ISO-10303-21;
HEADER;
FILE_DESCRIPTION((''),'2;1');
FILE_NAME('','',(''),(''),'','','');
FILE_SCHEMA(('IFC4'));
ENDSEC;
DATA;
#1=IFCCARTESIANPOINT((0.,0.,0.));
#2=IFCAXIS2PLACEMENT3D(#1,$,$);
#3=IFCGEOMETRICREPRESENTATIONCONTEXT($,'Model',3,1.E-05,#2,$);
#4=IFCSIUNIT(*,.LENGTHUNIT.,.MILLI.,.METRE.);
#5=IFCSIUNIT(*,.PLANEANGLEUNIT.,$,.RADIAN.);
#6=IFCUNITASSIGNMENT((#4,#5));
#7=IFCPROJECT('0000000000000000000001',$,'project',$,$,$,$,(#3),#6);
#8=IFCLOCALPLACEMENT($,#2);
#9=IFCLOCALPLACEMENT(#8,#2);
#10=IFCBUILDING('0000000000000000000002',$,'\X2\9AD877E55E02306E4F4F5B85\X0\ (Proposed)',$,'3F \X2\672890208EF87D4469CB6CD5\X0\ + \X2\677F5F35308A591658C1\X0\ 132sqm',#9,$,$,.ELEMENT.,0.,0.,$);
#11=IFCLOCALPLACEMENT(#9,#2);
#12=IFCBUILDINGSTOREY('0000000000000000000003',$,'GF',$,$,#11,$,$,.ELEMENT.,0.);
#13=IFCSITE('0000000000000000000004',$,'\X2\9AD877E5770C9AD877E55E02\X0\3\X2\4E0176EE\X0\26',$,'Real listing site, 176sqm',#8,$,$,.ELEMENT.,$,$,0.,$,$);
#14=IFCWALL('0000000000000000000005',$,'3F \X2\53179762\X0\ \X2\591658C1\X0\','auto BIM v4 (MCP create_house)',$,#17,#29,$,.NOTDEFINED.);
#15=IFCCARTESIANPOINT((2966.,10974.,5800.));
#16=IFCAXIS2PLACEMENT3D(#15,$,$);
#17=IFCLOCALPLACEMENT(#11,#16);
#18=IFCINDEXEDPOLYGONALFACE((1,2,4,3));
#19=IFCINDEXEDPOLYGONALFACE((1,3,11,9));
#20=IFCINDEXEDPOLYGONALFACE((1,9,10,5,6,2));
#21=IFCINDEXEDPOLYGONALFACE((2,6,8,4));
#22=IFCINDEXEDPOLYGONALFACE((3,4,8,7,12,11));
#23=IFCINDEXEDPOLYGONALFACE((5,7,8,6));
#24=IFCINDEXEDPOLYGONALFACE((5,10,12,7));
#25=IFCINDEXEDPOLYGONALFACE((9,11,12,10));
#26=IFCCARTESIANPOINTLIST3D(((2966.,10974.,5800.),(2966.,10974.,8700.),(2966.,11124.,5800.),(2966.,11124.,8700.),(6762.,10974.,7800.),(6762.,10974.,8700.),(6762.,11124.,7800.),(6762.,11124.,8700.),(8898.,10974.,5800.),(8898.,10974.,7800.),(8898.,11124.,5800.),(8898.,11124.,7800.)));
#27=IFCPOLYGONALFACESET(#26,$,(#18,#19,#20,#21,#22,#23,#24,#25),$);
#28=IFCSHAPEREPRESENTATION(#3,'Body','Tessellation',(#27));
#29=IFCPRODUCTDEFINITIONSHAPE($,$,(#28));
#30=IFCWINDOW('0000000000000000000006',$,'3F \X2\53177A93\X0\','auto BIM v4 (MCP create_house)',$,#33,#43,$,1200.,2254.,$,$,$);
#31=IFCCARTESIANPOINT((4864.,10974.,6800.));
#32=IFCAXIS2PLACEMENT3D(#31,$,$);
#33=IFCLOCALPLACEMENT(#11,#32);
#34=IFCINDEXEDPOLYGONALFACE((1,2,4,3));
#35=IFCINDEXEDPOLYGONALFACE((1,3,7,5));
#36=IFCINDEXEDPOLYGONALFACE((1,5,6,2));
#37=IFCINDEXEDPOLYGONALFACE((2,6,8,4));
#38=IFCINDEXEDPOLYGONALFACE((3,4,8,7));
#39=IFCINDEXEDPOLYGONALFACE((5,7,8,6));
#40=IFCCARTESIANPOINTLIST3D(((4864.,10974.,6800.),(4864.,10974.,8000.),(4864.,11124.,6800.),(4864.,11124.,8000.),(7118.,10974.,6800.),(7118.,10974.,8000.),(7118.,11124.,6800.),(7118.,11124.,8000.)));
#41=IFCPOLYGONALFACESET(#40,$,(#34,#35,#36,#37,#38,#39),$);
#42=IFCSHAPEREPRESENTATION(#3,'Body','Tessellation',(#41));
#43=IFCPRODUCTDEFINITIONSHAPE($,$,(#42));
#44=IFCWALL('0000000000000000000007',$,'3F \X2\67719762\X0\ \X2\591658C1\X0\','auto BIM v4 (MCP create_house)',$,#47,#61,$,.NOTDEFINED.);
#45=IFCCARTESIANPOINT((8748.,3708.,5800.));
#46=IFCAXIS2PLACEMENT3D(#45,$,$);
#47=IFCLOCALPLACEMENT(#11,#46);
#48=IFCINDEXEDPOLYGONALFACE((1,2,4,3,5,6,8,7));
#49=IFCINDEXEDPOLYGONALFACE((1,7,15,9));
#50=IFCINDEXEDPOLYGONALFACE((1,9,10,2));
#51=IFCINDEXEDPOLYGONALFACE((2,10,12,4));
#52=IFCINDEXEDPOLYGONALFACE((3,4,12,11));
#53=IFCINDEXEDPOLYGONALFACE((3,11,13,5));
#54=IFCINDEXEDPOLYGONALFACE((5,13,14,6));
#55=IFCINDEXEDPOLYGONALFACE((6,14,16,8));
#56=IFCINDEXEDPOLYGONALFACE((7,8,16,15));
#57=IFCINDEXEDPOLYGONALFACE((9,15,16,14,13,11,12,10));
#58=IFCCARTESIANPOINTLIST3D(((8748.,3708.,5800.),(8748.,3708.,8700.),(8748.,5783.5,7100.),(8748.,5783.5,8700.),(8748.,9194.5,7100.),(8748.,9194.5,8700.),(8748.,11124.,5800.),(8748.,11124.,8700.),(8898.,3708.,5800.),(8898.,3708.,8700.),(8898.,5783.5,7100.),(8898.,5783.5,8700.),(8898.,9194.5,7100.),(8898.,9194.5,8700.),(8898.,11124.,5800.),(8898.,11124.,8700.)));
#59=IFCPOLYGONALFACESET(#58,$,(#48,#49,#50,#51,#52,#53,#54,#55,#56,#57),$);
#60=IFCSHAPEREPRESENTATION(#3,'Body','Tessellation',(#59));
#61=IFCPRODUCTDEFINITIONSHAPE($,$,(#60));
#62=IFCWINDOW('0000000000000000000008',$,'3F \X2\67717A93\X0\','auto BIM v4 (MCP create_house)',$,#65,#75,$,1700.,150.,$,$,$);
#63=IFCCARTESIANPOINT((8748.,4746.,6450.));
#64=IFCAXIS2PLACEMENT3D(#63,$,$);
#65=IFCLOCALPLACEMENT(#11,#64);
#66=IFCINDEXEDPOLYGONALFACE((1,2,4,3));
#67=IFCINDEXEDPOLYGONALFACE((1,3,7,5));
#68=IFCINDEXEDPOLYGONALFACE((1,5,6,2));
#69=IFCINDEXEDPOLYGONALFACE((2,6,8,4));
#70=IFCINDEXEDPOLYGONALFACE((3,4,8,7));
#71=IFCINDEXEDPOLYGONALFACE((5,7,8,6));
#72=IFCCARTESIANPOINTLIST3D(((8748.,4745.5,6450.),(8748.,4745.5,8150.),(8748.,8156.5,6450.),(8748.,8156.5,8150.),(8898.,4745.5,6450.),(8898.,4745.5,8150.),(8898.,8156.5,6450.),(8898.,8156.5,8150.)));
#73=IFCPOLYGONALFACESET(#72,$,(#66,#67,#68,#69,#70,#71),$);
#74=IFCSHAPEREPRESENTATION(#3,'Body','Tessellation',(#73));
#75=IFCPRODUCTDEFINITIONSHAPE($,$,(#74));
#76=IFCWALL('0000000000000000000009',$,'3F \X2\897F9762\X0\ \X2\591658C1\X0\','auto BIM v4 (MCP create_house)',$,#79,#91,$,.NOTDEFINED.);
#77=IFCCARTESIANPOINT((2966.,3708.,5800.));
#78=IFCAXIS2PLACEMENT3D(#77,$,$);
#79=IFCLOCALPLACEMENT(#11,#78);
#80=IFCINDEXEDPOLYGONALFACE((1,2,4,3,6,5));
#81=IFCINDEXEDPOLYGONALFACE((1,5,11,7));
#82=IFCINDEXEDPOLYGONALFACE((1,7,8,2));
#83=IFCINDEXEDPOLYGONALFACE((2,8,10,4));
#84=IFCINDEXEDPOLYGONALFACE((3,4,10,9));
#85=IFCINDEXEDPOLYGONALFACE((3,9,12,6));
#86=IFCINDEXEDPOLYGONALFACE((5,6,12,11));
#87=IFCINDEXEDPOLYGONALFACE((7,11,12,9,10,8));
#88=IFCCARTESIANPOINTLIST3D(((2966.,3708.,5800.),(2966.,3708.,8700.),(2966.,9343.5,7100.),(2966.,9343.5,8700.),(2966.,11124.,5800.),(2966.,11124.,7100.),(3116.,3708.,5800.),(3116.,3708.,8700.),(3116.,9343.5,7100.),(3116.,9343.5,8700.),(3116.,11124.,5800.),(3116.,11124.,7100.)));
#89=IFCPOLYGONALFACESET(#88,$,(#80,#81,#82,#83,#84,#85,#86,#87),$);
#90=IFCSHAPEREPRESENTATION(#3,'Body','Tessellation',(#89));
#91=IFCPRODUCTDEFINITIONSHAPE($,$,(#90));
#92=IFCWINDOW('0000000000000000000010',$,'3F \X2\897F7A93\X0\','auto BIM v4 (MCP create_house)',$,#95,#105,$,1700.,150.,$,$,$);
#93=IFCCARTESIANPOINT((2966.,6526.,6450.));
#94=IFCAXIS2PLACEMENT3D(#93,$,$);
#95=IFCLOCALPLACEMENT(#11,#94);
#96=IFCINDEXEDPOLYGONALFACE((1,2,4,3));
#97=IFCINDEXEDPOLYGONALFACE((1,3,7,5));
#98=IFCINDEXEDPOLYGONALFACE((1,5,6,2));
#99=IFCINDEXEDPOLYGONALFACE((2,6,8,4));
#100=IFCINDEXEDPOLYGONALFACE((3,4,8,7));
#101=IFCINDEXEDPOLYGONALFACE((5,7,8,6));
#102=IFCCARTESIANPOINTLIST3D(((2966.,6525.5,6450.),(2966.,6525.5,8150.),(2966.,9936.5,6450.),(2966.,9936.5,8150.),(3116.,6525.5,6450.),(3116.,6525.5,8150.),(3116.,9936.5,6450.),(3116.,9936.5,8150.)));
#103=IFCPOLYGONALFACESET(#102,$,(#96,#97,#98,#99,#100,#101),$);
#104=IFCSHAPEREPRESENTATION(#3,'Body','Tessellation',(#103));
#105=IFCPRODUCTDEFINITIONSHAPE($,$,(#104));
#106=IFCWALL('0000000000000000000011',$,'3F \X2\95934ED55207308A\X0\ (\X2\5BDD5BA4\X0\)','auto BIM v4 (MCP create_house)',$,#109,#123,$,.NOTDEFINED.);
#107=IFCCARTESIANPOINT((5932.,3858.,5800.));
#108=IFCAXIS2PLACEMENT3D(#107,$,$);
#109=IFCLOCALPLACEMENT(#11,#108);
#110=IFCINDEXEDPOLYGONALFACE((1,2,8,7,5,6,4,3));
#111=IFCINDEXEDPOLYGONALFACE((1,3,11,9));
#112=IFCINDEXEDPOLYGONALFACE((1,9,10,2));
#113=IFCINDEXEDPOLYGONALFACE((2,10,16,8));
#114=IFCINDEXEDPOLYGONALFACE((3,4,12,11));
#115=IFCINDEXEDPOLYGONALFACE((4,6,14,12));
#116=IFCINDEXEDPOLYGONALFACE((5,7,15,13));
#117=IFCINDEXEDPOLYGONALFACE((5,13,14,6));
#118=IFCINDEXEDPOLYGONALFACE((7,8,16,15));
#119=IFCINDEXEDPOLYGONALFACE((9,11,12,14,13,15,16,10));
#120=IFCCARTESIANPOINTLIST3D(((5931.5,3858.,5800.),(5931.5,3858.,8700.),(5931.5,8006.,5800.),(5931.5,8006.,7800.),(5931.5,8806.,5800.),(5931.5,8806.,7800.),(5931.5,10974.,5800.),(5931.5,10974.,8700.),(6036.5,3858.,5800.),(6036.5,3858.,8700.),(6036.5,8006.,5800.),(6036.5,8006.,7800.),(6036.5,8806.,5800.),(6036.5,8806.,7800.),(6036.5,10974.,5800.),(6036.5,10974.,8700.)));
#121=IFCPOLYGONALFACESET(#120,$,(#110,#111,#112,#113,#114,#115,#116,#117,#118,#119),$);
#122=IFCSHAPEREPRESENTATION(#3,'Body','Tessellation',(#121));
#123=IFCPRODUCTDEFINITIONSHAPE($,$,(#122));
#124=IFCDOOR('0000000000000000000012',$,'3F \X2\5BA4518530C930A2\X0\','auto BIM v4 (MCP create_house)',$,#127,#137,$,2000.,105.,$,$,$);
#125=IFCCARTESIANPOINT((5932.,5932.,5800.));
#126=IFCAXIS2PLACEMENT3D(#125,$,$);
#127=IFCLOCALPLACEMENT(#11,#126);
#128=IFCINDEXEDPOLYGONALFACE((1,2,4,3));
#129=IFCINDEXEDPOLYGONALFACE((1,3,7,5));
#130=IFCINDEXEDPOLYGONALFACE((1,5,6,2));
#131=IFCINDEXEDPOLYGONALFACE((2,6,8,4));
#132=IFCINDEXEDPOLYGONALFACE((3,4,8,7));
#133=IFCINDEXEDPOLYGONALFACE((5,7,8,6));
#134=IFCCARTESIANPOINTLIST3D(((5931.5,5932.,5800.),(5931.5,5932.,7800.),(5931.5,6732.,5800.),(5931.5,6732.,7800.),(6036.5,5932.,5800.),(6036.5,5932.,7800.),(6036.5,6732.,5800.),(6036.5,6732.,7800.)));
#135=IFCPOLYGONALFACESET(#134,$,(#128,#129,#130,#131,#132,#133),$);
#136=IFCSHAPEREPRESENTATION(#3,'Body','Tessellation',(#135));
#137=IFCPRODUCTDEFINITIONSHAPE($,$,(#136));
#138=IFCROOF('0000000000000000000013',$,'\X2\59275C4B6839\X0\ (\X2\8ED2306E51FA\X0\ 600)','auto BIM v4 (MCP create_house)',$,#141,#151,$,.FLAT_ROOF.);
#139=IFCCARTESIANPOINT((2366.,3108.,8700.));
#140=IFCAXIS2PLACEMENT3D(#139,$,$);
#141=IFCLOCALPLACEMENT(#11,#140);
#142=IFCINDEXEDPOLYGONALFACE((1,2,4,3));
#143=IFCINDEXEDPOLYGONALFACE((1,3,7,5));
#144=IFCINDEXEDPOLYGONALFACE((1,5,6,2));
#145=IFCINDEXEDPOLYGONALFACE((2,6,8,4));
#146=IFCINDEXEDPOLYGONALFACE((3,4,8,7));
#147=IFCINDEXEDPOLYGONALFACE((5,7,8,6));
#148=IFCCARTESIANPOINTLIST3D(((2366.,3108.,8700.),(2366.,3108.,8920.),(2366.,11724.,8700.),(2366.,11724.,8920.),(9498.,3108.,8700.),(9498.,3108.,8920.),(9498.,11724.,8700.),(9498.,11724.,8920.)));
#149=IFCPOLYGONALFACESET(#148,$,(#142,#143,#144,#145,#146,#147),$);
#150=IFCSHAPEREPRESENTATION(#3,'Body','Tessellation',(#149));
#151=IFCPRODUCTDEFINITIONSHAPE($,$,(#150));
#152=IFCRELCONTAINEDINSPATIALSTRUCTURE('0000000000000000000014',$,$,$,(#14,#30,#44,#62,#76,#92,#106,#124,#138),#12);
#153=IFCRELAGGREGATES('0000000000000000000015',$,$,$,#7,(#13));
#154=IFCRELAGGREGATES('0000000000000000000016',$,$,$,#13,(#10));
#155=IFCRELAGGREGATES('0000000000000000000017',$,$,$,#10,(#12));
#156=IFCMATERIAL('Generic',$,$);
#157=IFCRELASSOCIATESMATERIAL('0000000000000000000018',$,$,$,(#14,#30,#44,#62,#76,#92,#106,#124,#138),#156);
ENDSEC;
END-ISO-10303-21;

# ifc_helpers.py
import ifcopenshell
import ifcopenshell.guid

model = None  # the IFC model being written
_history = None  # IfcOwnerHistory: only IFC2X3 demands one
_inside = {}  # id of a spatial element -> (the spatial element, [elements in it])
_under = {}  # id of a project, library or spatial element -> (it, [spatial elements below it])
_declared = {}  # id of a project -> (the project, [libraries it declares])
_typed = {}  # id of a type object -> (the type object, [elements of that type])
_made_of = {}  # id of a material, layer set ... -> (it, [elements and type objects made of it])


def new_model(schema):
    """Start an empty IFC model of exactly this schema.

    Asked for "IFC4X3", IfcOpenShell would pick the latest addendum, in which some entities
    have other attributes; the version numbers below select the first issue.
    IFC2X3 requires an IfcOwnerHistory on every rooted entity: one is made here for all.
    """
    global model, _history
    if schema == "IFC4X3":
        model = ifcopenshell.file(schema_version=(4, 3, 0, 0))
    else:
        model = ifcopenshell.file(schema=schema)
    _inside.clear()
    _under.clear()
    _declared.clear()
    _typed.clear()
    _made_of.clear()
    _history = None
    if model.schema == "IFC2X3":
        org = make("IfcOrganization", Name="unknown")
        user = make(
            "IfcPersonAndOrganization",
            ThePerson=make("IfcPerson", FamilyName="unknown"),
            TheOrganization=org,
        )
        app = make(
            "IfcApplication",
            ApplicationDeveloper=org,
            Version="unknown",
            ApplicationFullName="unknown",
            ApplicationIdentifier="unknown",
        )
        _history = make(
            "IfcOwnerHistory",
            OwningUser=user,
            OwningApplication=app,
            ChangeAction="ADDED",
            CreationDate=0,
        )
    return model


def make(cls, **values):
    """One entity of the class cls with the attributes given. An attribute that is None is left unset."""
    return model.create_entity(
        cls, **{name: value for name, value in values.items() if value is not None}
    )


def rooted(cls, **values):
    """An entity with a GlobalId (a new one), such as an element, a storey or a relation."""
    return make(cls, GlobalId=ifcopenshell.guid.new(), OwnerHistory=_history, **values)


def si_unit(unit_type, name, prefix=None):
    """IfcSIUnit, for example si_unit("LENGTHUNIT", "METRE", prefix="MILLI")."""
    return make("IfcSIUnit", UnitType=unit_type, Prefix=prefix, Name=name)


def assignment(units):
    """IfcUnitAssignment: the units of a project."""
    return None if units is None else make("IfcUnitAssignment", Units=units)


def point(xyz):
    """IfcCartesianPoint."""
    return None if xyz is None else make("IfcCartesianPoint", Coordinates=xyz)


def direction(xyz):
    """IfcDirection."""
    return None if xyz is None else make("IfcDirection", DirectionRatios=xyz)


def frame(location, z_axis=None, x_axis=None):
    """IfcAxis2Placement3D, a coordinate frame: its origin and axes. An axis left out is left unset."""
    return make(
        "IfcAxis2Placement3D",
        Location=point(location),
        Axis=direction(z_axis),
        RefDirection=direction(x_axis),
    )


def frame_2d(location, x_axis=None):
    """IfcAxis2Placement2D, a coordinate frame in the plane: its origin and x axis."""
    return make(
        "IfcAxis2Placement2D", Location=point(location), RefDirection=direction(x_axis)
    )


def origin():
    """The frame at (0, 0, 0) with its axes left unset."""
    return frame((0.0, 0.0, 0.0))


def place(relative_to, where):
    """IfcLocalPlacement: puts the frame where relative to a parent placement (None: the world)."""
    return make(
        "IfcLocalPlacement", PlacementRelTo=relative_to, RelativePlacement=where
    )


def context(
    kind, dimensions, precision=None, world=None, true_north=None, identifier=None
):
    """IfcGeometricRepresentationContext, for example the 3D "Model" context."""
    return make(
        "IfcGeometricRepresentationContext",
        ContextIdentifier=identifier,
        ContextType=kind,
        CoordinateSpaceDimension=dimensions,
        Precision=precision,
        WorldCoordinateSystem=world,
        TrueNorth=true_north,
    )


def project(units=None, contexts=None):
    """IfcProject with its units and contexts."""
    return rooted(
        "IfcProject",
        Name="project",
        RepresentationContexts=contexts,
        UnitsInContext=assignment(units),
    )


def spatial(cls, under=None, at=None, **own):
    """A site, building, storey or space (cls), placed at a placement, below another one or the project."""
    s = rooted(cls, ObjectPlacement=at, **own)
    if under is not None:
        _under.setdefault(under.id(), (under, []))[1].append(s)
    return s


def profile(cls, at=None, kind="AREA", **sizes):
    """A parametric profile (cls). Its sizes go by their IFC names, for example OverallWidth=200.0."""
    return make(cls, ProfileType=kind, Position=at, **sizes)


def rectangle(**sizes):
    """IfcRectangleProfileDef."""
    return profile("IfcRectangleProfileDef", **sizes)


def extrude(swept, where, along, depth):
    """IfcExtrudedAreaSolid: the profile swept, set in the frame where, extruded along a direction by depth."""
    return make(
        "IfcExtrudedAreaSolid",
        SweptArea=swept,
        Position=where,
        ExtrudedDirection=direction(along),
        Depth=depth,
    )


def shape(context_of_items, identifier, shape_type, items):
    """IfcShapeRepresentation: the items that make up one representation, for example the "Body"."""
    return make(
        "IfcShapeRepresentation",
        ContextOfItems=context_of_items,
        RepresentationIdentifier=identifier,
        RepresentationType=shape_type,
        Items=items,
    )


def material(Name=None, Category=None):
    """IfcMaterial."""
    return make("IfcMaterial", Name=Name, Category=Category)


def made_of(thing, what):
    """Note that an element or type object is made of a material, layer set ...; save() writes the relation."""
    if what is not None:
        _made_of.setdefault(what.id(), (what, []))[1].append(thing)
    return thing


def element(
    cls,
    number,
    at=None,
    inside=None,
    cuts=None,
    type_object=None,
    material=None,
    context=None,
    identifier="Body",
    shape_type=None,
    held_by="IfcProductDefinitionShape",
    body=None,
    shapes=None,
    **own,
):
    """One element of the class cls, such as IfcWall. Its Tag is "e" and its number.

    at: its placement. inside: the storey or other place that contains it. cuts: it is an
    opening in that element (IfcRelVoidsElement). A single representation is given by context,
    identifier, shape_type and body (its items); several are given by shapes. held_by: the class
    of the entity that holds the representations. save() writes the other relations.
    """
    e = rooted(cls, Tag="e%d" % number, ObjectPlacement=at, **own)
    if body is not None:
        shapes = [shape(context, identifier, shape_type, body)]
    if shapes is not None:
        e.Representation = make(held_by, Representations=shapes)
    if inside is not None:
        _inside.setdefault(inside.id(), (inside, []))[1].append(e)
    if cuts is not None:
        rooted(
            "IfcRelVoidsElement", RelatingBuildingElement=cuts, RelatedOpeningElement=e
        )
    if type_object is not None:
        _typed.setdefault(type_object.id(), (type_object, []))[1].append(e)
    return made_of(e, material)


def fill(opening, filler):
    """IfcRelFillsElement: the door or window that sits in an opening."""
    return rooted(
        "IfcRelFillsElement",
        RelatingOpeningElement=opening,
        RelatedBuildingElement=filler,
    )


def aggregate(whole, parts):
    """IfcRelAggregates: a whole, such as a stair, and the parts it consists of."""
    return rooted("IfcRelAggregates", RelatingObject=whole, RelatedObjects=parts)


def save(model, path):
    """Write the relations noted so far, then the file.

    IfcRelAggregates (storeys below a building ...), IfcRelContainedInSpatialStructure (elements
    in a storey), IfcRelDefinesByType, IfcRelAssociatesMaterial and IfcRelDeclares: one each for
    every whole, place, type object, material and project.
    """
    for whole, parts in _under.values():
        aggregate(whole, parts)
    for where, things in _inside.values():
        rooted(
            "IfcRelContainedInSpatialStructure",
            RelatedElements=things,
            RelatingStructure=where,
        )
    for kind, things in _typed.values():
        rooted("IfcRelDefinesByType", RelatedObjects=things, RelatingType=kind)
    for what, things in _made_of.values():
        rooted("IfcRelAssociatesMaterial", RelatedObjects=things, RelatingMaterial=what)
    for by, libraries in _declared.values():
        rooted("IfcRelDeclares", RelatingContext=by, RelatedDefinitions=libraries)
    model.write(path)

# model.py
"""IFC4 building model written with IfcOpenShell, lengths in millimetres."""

from ifc_helpers import new_model, si_unit, frame, frame_2d, origin, place, context, project, spatial, rectangle, extrude, material, element, fill, save


model = new_model("IFC4")

# Units and contexts
model_context = context("Model", 3, precision=1e-05, world=origin())
ifc_project = project(units=[si_unit("LENGTHUNIT", "METRE", prefix="MILLI"), si_unit("PLANEANGLEUNIT", "RADIAN")], contexts=[model_context])

# Site, building, storey
site_placement = place(None, origin())
site = spatial("IfcSite", under=ifc_project, at=site_placement, Name="高知県高知市3丁目26", ObjectType="Real listing site, 176sqm", CompositionType="ELEMENT", RefElevation=0.0)
building_placement = place(site_placement, origin())
building = spatial("IfcBuilding", under=site, at=building_placement, Name="高知市の住宅 (Proposed)", ObjectType="3F 木造軸組構法 + 板張り外壁 132sqm", CompositionType="ELEMENT", ElevationOfRefHeight=0.0, ElevationOfTerrain=0.0)
storey_placement = place(building_placement, origin())
storey = spatial("IfcBuildingStorey", under=building, at=storey_placement, Name="GF", CompositionType="ELEMENT", Elevation=0.0)

# Shared definitions
ifc_material = material(Name="Generic")

# Walls, openings, windows
wall_1_placement = place(storey_placement, frame((2966.0, 10974.0, 5800.0)))
wall_1 = element("IfcWall", 1, at=wall_1_placement, inside=storey, material=ifc_material, Name="3F 北面 外壁", Description="auto BIM v4 (MCP create_house)", PredefinedType="NOTDEFINED", context=model_context, shape_type="SweptSolid", body=[
    extrude(rectangle(XDim=5932.0, YDim=150.0, at=frame_2d((2966.0, 75.0))), frame((2966.0, 10974.0, 5800.0)), (0.0, 0.0, 1.0), 2900.0),
])
opening_1_placement = place(storey_placement, frame((4864.0, 10974.0, 6800.0)))
opening_1 = element("IfcOpeningElement", 2, at=opening_1_placement, cuts=wall_1, PredefinedType="NOTDEFINED", context=model_context, shape_type="SweptSolid", body=[
    extrude(rectangle(XDim=2254.0, YDim=150.0, at=frame_2d((1127.0, 75.0))), frame((4864.0, 10974.0, 6800.0)), (0.0, 0.0, 1.0), 1200.0),
])
window_1_placement = place(storey_placement, frame((4864.0, 10974.0, 6800.0)))
window_1 = element("IfcWindow", 3, at=window_1_placement, inside=storey, material=ifc_material, Name="3F 北窓", Description="auto BIM v4 (MCP create_house)", OverallHeight=1200.0, OverallWidth=2254.0, context=model_context, shape_type="SweptSolid", body=[
    extrude(rectangle(XDim=2254.0, YDim=150.0, at=frame_2d((1127.0, 75.0))), frame((4864.0, 10974.0, 6800.0)), (0.0, 0.0, 1.0), 1200.0),
])
fill(opening_1, window_1)
wall_2_placement = place(storey_placement, frame((8748.0, 3708.0, 5800.0)))
wall_2 = element("IfcWall", 4, at=wall_2_placement, inside=storey, material=ifc_material, Name="3F 東面 外壁", Description="auto BIM v4 (MCP create_house)", PredefinedType="NOTDEFINED", context=model_context, shape_type="SweptSolid", body=[
    extrude(rectangle(XDim=150.0, YDim=7416.0, at=frame_2d((75.0, 3708.0))), frame((8748.0, 3708.0, 5800.0)), (0.0, 0.0, 1.0), 2900.0),
])
opening_2_placement = place(storey_placement, frame((8748.0, 4746.0, 6450.0)))
opening_2 = element("IfcOpeningElement", 5, at=opening_2_placement, cuts=wall_2, PredefinedType="NOTDEFINED", context=model_context, shape_type="SweptSolid", body=[
    extrude(rectangle(XDim=150.0, YDim=3411.0, at=frame_2d((75.0, 1705.0))), frame((8748.0, 4746.0, 6450.0)), (0.0, 0.0, 1.0), 1700.0),
])
window_2_placement = place(storey_placement, frame((8748.0, 4746.0, 6450.0)))
window_2 = element("IfcWindow", 6, at=window_2_placement, inside=storey, material=ifc_material, Name="3F 東窓", Description="auto BIM v4 (MCP create_house)", OverallHeight=1700.0, OverallWidth=150.0, context=model_context, shape_type="SweptSolid", body=[
    extrude(rectangle(XDim=150.0, YDim=3411.0, at=frame_2d((75.0, 1705.0))), frame((8748.0, 4746.0, 6450.0)), (0.0, 0.0, 1.0), 1700.0),
])
fill(opening_2, window_2)
wall_3_placement = place(storey_placement, frame((2966.0, 3708.0, 5800.0)))
wall_3 = element("IfcWall", 7, at=wall_3_placement, inside=storey, material=ifc_material, Name="3F 西面 外壁", Description="auto BIM v4 (MCP create_house)", PredefinedType="NOTDEFINED", context=model_context, shape_type="SweptSolid", body=[
    extrude(rectangle(XDim=150.0, YDim=7416.0, at=frame_2d((75.0, 3708.0))), frame((2966.0, 3708.0, 5800.0)), (0.0, 0.0, 1.0), 2900.0),
])
opening_3_placement = place(storey_placement, frame((2966.0, 6526.0, 6450.0)))
opening_3 = element("IfcOpeningElement", 8, at=opening_3_placement, cuts=wall_3, PredefinedType="NOTDEFINED", context=model_context, shape_type="SweptSolid", body=[
    extrude(rectangle(XDim=150.0, YDim=3411.0, at=frame_2d((75.0, 1705.0))), frame((2966.0, 6526.0, 6450.0)), (0.0, 0.0, 1.0), 1700.0),
])
window_3_placement = place(storey_placement, frame((2966.0, 6526.0, 6450.0)))
window_3 = element("IfcWindow", 9, at=window_3_placement, inside=storey, material=ifc_material, Name="3F 西窓", Description="auto BIM v4 (MCP create_house)", OverallHeight=1700.0, OverallWidth=150.0, context=model_context, shape_type="SweptSolid", body=[
    extrude(rectangle(XDim=150.0, YDim=3411.0, at=frame_2d((75.0, 1705.0))), frame((2966.0, 6526.0, 6450.0)), (0.0, 0.0, 1.0), 1700.0),
])
fill(opening_3, window_3)

# Wall, opening, door
wall_4_placement = place(storey_placement, frame((5932.0, 3858.0, 5800.0)))
wall_4 = element("IfcWall", 10, at=wall_4_placement, inside=storey, material=ifc_material, Name="3F 間仕切り (寝室)", Description="auto BIM v4 (MCP create_house)", PredefinedType="NOTDEFINED", context=model_context, shape_type="SweptSolid", body=[
    extrude(rectangle(XDim=105.0, YDim=7116.0, at=frame_2d((52.0, 3558.0))), frame((5932.0, 3858.0, 5800.0)), (0.0, 0.0, 1.0), 2900.0),
])
opening_4_placement = place(storey_placement, frame((5932.0, 5932.0, 5800.0)))
opening_4 = element("IfcOpeningElement", 11, at=opening_4_placement, cuts=wall_4, PredefinedType="NOTDEFINED", context=model_context, shape_type="SweptSolid", body=[
    extrude(rectangle(XDim=105.0, YDim=800.0, at=frame_2d((52.0, 400.0))), frame((5932.0, 5932.0, 5800.0)), (0.0, 0.0, 1.0), 2000.0),
])
door_1_placement = place(storey_placement, frame((5932.0, 5932.0, 5800.0)))
door_1 = element("IfcDoor", 12, at=door_1_placement, inside=storey, material=ifc_material, Name="3F 室内ドア", Description="auto BIM v4 (MCP create_house)", OverallHeight=2000.0, OverallWidth=105.0, context=model_context, shape_type="SweptSolid", body=[
    extrude(rectangle(XDim=105.0, YDim=800.0, at=frame_2d((52.0, 400.0))), frame((5932.0, 5932.0, 5800.0)), (0.0, 0.0, 1.0), 2000.0),
])
fill(opening_4, door_1)

# Roof
roof_placement = place(storey_placement, frame((2366.0, 3108.0, 8700.0)))
element("IfcRoof", 13, at=roof_placement, inside=storey, material=ifc_material, Name="大屋根 (軒の出 600)", Description="auto BIM v4 (MCP create_house)", PredefinedType="FLAT_ROOF", context=model_context, shape_type="SweptSolid", body=[
    extrude(rectangle(XDim=7132.0, YDim=8616.0, at=frame_2d((3566.0, 4308.0))), frame((2366.0, 3108.0, 8700.0)), (0.0, 0.0, 1.0), 220.0),
])

save(model, "model.ifc")
